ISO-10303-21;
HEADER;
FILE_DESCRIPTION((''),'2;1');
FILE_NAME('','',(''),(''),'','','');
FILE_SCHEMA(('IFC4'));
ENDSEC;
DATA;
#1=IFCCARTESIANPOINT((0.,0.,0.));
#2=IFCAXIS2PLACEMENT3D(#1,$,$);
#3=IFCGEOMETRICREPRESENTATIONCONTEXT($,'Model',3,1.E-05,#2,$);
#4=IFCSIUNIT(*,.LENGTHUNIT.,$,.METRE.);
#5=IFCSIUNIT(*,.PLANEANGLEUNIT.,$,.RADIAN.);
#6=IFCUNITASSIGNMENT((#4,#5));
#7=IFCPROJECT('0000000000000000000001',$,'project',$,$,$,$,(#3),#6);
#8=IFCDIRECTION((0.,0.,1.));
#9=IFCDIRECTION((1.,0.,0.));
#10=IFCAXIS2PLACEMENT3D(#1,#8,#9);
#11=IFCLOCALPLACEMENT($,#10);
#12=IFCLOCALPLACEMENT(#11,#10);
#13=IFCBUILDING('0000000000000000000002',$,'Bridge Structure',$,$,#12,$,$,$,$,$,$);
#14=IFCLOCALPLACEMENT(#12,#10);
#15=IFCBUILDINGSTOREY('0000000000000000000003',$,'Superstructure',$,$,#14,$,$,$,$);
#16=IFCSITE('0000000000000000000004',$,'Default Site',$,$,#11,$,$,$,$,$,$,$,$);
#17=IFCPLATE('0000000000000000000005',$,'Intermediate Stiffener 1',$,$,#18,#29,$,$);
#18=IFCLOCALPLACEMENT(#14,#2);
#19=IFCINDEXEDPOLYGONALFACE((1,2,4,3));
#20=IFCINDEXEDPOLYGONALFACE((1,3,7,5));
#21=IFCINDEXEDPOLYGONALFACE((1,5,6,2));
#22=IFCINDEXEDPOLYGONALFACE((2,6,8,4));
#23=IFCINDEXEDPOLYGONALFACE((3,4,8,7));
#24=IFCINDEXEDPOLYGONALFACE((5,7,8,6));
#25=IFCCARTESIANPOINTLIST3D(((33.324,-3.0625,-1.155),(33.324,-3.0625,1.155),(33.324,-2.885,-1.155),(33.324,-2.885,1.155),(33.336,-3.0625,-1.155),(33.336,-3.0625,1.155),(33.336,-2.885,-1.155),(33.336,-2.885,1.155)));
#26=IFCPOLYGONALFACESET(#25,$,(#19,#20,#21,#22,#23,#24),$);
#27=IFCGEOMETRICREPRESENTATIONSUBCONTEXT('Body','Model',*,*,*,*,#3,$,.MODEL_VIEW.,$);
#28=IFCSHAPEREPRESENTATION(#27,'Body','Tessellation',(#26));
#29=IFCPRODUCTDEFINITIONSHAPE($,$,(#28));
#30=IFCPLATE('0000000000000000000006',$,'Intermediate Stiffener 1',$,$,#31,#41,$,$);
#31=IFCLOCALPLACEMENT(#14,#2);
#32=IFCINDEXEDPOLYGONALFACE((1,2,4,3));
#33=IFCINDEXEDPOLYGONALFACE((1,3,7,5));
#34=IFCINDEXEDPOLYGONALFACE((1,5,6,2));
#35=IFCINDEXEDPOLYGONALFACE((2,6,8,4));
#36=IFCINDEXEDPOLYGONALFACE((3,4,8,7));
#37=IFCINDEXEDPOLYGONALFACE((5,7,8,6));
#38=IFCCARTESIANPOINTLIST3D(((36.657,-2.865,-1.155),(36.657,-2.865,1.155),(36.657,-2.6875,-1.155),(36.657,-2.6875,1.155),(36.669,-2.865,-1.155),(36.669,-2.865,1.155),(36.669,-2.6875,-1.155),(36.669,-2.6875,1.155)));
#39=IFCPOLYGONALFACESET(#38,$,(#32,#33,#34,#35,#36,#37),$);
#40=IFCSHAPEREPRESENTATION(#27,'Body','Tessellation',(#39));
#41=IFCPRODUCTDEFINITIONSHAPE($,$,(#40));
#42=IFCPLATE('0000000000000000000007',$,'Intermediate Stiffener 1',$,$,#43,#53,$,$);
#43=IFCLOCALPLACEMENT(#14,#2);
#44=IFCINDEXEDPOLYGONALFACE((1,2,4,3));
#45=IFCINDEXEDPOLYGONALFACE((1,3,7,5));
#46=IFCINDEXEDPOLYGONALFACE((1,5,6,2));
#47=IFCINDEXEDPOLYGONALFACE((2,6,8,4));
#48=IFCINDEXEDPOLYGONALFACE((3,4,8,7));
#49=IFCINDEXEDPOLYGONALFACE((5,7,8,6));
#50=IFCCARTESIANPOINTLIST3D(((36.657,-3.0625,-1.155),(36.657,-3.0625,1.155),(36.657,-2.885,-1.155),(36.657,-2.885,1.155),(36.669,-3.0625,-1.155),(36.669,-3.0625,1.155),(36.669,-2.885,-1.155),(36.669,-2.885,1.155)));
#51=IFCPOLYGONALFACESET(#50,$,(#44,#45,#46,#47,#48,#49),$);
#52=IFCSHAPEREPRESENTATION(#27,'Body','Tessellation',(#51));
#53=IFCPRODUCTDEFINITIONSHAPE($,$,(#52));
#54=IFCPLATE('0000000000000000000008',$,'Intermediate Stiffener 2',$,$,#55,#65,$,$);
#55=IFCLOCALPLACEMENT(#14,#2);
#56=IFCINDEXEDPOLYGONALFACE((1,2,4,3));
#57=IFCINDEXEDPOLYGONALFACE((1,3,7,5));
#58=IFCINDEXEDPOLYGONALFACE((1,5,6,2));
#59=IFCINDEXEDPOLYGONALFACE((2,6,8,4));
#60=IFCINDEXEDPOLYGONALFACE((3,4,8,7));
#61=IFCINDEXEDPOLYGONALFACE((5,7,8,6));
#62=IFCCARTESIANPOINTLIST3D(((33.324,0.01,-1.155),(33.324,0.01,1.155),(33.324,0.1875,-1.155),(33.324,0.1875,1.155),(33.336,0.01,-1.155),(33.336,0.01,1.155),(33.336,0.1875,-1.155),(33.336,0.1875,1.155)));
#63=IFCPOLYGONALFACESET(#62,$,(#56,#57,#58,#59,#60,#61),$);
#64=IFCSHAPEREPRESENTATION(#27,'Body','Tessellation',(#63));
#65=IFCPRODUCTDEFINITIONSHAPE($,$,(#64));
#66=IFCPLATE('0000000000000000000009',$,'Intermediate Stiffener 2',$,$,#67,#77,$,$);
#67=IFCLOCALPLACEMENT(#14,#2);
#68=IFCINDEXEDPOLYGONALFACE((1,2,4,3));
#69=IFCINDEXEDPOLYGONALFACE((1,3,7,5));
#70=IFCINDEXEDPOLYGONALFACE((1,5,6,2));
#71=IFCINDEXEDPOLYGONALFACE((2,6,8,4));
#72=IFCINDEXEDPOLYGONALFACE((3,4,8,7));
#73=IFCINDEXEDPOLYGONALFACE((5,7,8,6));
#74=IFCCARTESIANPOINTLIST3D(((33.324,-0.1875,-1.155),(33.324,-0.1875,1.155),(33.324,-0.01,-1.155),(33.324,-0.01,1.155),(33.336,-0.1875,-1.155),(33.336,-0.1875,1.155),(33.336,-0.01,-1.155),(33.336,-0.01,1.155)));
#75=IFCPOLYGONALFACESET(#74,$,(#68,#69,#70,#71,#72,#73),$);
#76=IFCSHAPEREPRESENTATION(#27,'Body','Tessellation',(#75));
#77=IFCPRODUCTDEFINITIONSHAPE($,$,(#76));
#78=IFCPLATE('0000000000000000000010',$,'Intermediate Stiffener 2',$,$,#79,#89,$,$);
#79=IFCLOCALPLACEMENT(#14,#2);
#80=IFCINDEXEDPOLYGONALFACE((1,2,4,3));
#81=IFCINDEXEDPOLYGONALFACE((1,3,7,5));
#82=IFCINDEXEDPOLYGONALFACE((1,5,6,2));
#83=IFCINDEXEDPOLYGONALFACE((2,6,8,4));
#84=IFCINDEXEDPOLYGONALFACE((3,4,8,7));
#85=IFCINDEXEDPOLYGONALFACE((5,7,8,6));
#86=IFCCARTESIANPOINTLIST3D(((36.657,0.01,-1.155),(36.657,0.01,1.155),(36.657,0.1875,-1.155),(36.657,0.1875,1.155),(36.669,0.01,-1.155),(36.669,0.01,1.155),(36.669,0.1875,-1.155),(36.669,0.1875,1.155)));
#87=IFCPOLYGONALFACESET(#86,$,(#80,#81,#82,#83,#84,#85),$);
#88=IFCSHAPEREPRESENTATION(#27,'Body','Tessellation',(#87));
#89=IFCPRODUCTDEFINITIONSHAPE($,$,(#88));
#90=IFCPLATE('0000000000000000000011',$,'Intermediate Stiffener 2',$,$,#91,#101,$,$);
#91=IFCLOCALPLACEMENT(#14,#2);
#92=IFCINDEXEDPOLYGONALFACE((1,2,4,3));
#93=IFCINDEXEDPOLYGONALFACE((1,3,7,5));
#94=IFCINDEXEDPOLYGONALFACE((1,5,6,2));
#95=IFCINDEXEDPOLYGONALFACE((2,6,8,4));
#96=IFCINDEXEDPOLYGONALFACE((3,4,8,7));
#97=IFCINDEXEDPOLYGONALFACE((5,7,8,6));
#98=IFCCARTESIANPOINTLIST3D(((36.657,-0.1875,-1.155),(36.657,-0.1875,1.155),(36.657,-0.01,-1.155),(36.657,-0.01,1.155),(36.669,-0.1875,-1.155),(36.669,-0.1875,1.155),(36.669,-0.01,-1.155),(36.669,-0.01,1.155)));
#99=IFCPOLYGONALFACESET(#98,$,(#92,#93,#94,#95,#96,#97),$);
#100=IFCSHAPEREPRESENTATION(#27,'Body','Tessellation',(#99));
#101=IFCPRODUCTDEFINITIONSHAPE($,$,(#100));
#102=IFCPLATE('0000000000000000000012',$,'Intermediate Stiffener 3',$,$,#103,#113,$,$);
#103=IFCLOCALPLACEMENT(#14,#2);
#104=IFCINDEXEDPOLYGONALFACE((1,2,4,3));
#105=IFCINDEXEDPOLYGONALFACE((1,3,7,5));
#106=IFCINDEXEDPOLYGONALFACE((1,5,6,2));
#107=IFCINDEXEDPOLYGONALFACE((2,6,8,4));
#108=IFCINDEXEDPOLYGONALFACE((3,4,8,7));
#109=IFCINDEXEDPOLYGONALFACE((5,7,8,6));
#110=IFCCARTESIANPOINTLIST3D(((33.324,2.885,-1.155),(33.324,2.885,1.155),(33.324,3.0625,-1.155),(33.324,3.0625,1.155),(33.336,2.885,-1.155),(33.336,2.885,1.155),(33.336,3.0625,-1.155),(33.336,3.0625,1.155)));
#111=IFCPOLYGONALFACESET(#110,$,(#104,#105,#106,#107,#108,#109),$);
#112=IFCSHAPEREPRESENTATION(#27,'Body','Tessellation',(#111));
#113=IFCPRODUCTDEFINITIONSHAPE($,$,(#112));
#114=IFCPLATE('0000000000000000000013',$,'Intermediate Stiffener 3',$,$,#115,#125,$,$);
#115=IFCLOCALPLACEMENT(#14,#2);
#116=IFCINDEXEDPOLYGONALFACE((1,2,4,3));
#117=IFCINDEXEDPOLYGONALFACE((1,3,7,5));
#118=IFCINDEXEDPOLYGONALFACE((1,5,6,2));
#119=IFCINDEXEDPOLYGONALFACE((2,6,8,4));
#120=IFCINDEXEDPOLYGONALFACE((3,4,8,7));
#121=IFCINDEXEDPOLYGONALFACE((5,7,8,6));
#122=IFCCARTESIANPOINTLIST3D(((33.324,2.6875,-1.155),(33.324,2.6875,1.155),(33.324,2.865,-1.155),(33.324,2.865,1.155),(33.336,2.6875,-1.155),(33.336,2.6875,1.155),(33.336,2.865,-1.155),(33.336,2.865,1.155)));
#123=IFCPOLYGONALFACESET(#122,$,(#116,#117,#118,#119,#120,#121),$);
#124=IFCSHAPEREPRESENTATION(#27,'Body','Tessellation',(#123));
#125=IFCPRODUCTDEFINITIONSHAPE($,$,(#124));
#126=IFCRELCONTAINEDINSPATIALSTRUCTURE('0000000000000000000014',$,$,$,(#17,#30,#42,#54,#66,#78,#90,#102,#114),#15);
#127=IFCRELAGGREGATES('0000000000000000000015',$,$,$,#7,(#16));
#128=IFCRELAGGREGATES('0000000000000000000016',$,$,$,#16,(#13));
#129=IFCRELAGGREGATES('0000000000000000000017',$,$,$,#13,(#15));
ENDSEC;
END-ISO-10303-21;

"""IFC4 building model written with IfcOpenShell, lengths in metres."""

from ifc_helpers import new_model, si_unit, frame, origin, origin_with_axes, origin_2d_with_axis, place, context, subcontext, project, spatial, rectangle, extrude, element, save


model = new_model("IFC4")

# Units and contexts
model_context = context("Model", 3, precision=1e-05, world=origin())
body_context = subcontext(model_context, "Body", "Model", "MODEL_VIEW")
ifc_project = project(units=[si_unit("LENGTHUNIT", "METRE"), si_unit("PLANEANGLEUNIT", "RADIAN")], contexts=[model_context])

# Site, building, storey
site_placement = place(None, origin_with_axes())
site = spatial("IfcSite", under=ifc_project, at=site_placement, Name="Default Site")
building_placement = place(site_placement, origin_with_axes())
building = spatial("IfcBuilding", under=site, at=building_placement, Name="Bridge Structure")
storey_placement = place(building_placement, origin_with_axes())
storey = spatial("IfcBuildingStorey", under=building, at=storey_placement, Name="Superstructure")

# Plates
for number, where, z_axis, x_axis, name in (
    (1, (33.33, -2.9737, -1.155), (0.0, 0.0, 1.0), (1.0, 0.0, 0.0), "Intermediate Stiffener 1"),
    (2, (36.663, -2.7763, -1.155), (0.0, 0.0, 1.0), (1.0, 0.0, 0.0), "Intermediate Stiffener 1"),
    (3, (36.663, -2.9737, -1.155), (0.0, 0.0, 1.0), (1.0, 0.0, 0.0), "Intermediate Stiffener 1"),
    (4, (33.33, 0.0988, -1.155), (0.0, 0.0, 1.0), (1.0, 0.0, 0.0), "Intermediate Stiffener 2"),
    (5, (33.33, -0.0988, -1.155), (0.0, 0.0, 1.0), (1.0, 0.0, 0.0), "Intermediate Stiffener 2"),
    (6, (36.663, 0.0988, -1.155), (0.0, 0.0, 1.0), (1.0, 0.0, 0.0), "Intermediate Stiffener 2"),
    (7, (36.663, -0.0988, -1.155), (0.0, 0.0, 1.0), (1.0, 0.0, 0.0), "Intermediate Stiffener 2"),
    (8, (33.33, 2.9737, -1.155), (0.0, 0.0, 1.0), (1.0, 0.0, 0.0), "Intermediate Stiffener 3"),
    (9, (33.33, 2.7763, -1.155), (0.0, 0.0, 1.0), (1.0, 0.0, 0.0), "Intermediate Stiffener 3"),
):
    element("IfcPlate", number, at=place(storey_placement, frame(where, z_axis=z_axis, x_axis=x_axis)), inside=storey, Name=name, context=body_context, shape_type="SweptSolid", body=[
        extrude(rectangle(XDim=0.012, YDim=0.1775, at=origin_2d_with_axis()), origin_with_axes(), (0.0, 0.0, 1.0), 2.31),
    ])

save(model, "model.ifc")
